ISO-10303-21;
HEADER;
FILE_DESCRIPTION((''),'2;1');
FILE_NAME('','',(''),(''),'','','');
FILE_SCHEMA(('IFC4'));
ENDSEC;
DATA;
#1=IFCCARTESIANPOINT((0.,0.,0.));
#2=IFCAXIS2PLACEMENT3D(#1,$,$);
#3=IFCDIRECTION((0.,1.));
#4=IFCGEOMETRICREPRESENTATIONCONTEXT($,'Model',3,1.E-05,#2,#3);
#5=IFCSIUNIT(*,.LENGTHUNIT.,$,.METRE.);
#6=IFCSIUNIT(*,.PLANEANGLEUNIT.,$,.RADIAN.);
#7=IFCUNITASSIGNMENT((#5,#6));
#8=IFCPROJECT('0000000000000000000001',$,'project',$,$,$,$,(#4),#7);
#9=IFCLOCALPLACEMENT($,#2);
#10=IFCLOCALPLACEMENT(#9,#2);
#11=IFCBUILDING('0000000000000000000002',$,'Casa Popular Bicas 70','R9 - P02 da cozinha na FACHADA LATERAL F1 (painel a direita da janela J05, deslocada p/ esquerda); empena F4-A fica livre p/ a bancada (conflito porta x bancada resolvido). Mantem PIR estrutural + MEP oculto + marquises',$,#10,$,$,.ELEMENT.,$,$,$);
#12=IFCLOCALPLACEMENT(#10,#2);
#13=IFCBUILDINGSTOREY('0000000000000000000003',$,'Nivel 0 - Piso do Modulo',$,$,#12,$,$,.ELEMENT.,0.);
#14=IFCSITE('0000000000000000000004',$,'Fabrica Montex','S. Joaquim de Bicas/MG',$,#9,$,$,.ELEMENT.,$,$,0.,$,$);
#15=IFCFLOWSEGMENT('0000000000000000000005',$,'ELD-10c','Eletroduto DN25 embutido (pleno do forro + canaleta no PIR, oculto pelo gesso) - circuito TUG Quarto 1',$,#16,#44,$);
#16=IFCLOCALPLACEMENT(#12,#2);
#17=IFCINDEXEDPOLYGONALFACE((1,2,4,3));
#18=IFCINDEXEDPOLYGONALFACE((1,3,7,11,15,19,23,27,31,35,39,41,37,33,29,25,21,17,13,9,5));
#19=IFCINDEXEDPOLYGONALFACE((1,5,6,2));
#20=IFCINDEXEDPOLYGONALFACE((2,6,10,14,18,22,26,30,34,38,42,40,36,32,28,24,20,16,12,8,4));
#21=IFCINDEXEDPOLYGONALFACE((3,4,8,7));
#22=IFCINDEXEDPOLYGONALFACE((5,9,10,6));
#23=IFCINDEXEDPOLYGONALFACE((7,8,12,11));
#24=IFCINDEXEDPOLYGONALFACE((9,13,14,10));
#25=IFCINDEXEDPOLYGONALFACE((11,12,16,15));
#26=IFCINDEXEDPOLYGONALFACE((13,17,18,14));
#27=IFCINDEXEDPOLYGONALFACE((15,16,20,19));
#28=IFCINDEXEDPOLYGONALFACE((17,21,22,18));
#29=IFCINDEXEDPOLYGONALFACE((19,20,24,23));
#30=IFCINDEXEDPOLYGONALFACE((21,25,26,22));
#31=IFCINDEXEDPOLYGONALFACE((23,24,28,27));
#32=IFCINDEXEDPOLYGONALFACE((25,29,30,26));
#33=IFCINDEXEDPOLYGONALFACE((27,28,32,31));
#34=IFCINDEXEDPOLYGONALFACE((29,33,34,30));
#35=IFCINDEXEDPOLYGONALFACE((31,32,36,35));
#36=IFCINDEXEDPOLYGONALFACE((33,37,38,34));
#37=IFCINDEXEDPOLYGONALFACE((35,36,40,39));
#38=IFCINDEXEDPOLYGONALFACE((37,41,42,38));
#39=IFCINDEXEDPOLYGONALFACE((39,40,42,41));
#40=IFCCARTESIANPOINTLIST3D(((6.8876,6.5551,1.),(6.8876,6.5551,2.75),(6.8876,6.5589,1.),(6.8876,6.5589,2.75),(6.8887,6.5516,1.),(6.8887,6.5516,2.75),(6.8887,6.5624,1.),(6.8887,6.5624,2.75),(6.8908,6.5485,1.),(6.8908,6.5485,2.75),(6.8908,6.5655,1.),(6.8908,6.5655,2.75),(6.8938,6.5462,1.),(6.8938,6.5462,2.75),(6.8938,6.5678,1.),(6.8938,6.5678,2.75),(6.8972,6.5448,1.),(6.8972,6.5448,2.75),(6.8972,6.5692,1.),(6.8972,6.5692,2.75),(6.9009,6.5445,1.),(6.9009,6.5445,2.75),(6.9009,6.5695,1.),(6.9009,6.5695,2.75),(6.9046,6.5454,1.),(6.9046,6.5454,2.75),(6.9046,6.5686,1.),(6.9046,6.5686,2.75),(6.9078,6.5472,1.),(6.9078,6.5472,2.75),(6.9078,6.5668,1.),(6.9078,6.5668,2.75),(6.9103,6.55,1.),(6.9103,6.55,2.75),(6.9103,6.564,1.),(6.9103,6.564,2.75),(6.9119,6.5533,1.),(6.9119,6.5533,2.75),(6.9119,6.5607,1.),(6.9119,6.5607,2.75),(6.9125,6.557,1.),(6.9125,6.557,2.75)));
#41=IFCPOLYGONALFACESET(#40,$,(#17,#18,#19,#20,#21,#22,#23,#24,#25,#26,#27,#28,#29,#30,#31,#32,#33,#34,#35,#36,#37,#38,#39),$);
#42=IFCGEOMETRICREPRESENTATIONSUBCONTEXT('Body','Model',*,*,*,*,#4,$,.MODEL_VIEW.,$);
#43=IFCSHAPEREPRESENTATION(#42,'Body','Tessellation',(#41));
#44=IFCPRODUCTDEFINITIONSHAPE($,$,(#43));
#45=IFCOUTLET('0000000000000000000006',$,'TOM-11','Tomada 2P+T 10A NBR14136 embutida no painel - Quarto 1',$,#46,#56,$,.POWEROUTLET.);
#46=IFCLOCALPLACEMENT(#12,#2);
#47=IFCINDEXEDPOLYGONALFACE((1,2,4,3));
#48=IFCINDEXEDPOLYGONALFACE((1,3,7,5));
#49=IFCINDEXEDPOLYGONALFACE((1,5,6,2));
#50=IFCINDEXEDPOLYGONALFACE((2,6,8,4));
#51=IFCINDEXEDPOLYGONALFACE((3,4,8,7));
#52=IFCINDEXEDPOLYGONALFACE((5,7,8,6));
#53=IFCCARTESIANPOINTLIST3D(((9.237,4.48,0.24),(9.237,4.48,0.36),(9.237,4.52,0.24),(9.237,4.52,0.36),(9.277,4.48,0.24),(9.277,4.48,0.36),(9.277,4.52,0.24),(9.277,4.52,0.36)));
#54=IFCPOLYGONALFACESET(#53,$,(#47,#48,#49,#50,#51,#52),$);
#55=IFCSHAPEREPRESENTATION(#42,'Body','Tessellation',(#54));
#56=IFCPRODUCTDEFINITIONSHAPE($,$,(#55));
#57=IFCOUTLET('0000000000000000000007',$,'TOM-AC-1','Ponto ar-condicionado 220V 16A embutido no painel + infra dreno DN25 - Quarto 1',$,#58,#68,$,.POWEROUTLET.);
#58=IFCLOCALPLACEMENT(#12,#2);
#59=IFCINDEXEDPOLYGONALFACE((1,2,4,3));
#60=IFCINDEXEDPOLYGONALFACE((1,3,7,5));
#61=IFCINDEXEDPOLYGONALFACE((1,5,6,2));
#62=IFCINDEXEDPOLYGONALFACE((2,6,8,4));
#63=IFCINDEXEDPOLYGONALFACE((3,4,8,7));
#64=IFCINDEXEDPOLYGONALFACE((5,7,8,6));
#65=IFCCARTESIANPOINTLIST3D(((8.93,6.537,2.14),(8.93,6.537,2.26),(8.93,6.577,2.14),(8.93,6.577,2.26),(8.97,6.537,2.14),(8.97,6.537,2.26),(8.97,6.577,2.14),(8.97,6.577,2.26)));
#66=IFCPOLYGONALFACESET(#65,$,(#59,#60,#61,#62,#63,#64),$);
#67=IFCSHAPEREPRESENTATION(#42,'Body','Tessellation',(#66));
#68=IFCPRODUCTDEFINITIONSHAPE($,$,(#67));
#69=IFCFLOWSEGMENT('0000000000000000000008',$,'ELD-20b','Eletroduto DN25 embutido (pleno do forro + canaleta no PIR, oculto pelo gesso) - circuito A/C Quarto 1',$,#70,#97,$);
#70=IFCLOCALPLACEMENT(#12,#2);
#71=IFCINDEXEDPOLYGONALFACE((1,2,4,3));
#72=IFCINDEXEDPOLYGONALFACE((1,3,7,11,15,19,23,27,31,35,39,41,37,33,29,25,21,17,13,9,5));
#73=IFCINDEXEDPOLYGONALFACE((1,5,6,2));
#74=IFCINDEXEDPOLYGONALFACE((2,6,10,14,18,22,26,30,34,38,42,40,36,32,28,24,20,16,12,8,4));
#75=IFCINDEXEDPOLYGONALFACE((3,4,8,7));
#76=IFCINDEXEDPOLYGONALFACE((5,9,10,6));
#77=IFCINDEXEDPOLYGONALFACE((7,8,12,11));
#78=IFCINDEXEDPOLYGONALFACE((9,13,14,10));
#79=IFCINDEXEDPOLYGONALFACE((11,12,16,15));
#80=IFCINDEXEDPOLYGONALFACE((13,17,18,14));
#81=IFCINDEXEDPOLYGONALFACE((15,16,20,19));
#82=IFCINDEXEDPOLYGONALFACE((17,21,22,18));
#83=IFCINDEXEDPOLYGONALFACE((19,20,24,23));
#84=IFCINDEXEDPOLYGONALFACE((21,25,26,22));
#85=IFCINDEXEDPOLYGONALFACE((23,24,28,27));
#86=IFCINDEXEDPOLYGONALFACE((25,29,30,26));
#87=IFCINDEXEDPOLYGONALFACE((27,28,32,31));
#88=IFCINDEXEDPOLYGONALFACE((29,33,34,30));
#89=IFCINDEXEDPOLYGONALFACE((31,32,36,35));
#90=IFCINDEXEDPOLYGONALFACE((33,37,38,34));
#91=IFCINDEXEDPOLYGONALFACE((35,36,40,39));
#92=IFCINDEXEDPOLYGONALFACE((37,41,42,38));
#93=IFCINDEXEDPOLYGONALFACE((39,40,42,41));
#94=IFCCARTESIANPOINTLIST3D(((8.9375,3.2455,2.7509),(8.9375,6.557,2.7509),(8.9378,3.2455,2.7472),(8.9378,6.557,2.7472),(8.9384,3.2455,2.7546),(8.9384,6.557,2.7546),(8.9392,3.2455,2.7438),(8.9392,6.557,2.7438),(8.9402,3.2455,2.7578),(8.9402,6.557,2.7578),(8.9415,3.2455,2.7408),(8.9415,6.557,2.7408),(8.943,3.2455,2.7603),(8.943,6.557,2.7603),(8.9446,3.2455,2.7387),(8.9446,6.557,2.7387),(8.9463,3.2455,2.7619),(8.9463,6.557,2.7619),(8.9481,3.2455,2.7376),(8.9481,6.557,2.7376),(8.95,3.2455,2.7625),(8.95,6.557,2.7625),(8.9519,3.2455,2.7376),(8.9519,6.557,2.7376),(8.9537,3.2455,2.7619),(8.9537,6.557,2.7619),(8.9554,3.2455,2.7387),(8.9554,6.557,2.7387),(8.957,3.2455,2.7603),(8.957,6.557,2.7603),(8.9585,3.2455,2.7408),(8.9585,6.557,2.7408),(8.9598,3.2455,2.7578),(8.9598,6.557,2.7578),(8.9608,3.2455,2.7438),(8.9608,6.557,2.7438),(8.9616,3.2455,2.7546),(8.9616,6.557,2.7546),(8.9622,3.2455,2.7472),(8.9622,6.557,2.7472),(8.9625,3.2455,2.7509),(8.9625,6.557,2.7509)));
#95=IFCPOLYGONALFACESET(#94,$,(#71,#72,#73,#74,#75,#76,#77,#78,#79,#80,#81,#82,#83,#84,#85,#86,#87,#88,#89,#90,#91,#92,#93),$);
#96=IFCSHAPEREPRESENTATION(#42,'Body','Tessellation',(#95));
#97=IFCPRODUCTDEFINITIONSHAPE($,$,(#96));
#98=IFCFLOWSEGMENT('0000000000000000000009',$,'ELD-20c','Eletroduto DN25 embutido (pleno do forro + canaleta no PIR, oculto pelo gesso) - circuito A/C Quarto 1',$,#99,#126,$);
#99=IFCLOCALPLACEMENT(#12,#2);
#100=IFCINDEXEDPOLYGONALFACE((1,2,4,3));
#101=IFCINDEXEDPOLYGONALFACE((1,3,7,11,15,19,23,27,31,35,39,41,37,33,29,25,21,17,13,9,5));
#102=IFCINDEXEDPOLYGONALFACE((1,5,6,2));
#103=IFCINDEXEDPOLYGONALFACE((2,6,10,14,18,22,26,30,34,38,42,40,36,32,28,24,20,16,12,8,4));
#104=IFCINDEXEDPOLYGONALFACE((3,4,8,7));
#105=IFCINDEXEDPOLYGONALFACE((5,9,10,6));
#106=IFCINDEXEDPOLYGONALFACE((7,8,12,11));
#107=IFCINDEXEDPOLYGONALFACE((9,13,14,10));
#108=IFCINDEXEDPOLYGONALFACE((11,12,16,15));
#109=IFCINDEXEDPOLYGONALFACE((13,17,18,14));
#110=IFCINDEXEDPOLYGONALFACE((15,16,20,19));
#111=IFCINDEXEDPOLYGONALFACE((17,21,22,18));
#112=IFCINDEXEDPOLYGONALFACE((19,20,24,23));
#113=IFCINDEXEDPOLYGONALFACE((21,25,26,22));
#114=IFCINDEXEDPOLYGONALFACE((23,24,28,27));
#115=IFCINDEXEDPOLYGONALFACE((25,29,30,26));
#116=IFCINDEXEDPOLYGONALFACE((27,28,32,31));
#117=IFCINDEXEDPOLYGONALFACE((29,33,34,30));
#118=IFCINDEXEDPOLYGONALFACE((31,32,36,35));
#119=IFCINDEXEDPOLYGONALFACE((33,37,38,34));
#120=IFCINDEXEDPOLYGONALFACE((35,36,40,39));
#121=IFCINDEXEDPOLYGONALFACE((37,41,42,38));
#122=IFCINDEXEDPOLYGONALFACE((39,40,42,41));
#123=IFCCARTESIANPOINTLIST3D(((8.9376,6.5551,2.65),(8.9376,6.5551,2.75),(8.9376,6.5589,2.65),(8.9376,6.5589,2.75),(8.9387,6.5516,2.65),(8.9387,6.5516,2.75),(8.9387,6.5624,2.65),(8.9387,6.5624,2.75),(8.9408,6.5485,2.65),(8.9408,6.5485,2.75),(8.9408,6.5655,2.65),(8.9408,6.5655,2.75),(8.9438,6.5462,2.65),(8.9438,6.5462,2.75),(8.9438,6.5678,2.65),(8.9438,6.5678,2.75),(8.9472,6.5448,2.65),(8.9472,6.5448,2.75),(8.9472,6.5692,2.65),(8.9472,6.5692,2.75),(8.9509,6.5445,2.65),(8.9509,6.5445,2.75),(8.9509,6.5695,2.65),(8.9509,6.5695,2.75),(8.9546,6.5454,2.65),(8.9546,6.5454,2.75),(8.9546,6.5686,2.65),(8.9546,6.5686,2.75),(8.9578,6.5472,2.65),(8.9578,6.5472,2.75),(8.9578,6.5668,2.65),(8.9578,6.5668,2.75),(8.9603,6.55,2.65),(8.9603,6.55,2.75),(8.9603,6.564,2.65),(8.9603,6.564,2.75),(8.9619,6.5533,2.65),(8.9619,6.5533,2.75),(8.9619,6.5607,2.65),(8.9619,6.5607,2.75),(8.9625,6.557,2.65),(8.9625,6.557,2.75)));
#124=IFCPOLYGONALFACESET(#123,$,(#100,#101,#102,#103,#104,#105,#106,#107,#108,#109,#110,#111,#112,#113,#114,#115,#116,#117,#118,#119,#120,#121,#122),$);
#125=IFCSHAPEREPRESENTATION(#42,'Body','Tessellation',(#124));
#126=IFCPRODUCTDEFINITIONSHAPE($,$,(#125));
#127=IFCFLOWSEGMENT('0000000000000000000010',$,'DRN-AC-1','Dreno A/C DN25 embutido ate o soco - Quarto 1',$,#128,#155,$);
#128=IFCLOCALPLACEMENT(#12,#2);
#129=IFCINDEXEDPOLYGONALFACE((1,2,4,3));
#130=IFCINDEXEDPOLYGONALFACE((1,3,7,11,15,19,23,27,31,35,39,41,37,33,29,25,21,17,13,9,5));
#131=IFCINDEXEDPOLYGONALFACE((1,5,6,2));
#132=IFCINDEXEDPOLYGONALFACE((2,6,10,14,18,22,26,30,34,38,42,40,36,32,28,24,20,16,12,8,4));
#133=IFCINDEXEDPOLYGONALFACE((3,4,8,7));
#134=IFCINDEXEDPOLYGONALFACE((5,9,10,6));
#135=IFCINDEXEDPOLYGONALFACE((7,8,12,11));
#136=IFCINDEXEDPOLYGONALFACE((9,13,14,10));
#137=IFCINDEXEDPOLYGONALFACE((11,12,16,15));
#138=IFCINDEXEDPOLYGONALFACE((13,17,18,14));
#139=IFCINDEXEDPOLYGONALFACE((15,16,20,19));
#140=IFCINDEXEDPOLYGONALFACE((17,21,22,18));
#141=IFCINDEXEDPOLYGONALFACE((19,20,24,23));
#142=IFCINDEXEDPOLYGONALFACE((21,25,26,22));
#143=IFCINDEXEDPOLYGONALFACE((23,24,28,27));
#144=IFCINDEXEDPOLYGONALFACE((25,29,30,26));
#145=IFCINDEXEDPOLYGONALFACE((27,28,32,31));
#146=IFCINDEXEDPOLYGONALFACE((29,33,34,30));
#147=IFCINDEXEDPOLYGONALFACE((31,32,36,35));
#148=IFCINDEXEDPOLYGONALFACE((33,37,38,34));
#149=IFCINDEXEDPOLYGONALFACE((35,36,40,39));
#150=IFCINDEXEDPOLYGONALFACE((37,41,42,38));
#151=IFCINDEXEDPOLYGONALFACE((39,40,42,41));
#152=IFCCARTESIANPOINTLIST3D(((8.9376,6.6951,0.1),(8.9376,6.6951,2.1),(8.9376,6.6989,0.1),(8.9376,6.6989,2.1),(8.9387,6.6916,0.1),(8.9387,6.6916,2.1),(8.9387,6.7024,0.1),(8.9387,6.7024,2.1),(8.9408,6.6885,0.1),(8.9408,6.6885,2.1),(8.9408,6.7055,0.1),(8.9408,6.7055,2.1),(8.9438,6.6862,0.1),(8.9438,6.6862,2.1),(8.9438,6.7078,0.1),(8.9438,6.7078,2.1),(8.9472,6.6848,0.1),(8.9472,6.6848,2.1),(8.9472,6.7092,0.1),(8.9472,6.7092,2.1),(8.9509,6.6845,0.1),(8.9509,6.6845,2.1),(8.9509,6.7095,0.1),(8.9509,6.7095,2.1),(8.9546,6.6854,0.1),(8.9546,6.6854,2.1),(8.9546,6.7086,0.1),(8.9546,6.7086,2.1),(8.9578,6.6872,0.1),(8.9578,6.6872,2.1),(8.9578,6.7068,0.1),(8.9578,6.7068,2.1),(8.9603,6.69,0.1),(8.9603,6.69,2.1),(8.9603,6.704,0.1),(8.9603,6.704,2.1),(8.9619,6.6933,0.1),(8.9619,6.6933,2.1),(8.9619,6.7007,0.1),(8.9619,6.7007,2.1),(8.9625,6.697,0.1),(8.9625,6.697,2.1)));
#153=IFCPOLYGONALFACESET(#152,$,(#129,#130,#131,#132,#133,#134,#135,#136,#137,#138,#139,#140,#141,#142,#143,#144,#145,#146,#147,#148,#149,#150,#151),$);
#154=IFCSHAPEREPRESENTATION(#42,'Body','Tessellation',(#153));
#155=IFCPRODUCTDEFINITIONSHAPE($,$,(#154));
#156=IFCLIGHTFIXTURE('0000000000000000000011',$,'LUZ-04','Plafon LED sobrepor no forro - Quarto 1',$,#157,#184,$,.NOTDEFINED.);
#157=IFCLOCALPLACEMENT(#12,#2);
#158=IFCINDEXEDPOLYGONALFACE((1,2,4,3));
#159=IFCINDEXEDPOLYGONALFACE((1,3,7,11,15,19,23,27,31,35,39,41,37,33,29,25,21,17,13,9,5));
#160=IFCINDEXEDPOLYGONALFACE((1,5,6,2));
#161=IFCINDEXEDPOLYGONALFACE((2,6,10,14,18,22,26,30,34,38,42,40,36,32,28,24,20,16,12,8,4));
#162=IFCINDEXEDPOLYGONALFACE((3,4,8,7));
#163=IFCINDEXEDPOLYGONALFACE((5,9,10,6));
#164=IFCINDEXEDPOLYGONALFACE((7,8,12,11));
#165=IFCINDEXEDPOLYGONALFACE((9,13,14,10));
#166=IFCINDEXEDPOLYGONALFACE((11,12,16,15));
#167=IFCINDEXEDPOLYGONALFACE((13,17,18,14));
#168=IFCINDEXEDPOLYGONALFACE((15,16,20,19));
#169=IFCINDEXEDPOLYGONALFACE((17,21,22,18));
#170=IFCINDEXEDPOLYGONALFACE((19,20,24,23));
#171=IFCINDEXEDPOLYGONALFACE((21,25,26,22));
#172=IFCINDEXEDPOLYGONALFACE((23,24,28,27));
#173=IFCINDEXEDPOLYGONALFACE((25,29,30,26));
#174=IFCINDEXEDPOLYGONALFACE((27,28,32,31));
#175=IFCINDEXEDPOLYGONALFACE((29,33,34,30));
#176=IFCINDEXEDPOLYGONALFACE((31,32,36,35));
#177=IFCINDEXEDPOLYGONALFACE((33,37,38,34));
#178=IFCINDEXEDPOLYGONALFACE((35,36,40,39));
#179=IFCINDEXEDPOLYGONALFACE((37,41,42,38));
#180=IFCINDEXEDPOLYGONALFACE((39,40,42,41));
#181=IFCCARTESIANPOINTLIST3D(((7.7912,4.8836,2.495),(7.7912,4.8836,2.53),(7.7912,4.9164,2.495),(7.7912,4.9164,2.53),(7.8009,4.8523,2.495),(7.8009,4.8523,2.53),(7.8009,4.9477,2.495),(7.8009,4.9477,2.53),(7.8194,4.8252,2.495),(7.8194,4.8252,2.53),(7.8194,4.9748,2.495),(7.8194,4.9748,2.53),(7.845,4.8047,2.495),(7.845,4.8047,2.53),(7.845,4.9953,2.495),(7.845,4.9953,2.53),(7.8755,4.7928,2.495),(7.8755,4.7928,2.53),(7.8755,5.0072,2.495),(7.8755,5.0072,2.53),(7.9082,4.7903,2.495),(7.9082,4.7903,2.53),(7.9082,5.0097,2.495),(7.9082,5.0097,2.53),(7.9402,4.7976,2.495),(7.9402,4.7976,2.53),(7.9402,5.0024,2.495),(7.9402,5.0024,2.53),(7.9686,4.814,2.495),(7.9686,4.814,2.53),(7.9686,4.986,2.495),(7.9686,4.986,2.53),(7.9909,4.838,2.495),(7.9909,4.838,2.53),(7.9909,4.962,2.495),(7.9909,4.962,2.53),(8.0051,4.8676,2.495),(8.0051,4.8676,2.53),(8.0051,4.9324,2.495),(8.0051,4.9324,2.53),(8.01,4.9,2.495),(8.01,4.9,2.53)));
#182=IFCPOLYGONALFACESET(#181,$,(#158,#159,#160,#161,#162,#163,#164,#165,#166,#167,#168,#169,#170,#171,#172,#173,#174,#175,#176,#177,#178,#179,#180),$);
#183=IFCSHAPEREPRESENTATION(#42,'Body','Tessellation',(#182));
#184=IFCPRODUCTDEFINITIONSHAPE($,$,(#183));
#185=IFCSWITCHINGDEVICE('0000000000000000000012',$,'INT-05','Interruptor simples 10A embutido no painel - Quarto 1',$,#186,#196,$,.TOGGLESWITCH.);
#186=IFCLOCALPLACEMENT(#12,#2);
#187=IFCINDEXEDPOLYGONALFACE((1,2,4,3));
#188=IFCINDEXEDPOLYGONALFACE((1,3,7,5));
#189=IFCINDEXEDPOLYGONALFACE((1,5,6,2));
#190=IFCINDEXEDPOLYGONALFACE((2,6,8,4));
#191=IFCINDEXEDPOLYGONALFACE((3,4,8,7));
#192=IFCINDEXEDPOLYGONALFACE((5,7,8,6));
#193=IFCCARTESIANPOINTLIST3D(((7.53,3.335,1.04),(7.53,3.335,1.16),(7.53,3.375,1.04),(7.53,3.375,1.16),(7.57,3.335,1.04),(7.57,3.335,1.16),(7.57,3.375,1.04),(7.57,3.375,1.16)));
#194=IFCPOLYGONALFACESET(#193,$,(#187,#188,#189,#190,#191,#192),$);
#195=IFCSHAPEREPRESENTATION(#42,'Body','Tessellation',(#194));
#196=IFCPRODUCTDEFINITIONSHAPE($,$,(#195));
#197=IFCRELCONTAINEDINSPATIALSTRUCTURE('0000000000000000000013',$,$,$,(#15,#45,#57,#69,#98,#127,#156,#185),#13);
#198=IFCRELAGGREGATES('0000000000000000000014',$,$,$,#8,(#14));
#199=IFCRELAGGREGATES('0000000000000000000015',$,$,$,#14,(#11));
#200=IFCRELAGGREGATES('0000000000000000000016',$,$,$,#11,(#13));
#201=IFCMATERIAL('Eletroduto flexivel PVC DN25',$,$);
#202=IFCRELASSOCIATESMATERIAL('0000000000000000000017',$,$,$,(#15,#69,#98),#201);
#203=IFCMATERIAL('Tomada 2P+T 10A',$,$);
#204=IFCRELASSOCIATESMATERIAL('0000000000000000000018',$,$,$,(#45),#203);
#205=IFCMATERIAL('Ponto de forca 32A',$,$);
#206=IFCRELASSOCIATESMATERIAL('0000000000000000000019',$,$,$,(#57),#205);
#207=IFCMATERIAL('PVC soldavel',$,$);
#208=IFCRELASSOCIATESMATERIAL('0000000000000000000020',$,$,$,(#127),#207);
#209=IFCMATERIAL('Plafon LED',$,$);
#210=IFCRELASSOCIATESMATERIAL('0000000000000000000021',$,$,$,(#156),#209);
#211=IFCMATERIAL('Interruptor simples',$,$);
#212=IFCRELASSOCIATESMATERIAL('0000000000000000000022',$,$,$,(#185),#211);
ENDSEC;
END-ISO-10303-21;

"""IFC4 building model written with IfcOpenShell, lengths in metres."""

from ifc_helpers import new_model, si_unit, direction, frame, frame_2d, origin, origin_2d, place, context, subcontext, project, spatial, rectangle, circle, extrude, material, element, save


model = new_model("IFC4")

# Units and contexts
model_context = context("Model", 3, precision=1e-05, world=origin(), true_north=direction((0.0, 1.0)))
body_context = subcontext(model_context, "Body", "Model", "MODEL_VIEW")
ifc_project = project(units=[si_unit("LENGTHUNIT", "METRE"), si_unit("PLANEANGLEUNIT", "RADIAN")], contexts=[model_context])

# Site, building, storey
site_placement = place(None, origin())
site = spatial("IfcSite", under=ifc_project, at=site_placement, Name="Fabrica Montex", Description="S. Joaquim de Bicas/MG", CompositionType="ELEMENT", RefElevation=0.0)
building_placement = place(site_placement, origin())
building = spatial("IfcBuilding", under=site, at=building_placement, Name="Casa Popular Bicas 70", Description="R9 - P02 da cozinha na FACHADA LATERAL F1 (painel a direita da janela J05, deslocada p/ esquerda); empena F4-A fica livre p/ a bancada (conflito porta x bancada resolvido). Mantem PIR estrutural + MEP oculto + marquises", CompositionType="ELEMENT")
storey_placement = place(building_placement, origin())
storey = spatial("IfcBuildingStorey", under=building, at=storey_placement, Name="Nivel 0 - Piso do Modulo", CompositionType="ELEMENT", Elevation=0.0)

# Shared definitions
ifc_material_1 = material(Name="Eletroduto flexivel PVC DN25")

# Shared definitions
ifc_material_2 = material(Name="Tomada 2P+T 10A")

# Flow segment
flow_segment_1_placement = place(storey_placement, frame((6.9, 6.557, 2.75), z_axis=(0.0, 0.0, -1.0), x_axis=(1.0, 0.0, 0.0)))
element("IfcFlowSegment", 1, at=flow_segment_1_placement, inside=storey, material=ifc_material_1, Name="ELD-10c", Description="Eletroduto DN25 embutido (pleno do forro + canaleta no PIR, oculto pelo gesso) - circuito TUG Quarto 1", context=body_context, shape_type="SweptSolid", body=[
    extrude(circle(Radius=0.0125, at=origin_2d()), origin(), (0.0, 0.0, 1.0), 1.75),
])

# Outlets
outlet_1_placement = place(storey_placement, frame((9.237, 4.48, 0.24)))
element("IfcOutlet", 2, at=outlet_1_placement, inside=storey, material=ifc_material_2, Name="TOM-11", Description="Tomada 2P+T 10A NBR14136 embutida no painel - Quarto 1", PredefinedType="POWEROUTLET", context=body_context, shape_type="SweptSolid", body=[
    extrude(rectangle(XDim=0.04, YDim=0.04, at=frame_2d((0.02, 0.02))), origin(), (0.0, 0.0, 1.0), 0.12),
])
ifc_material_3 = material(Name="Ponto de forca 32A")
outlet_2_placement = place(storey_placement, frame((8.93, 6.537, 2.14)))
element("IfcOutlet", 3, at=outlet_2_placement, inside=storey, material=ifc_material_3, Name="TOM-AC-1", Description="Ponto ar-condicionado 220V 16A embutido no painel + infra dreno DN25 - Quarto 1", PredefinedType="POWEROUTLET", context=body_context, shape_type="SweptSolid", body=[
    extrude(rectangle(XDim=0.04, YDim=0.04, at=frame_2d((0.02, 0.02))), origin(), (0.0, 0.0, 1.0), 0.12),
])

# Flow segments
flow_segment_2_placement = place(storey_placement, frame((8.95, 3.2455, 2.75), z_axis=(0.0, 1.0, 0.0), x_axis=(0.0, 0.0, 1.0)))
element("IfcFlowSegment", 4, at=flow_segment_2_placement, inside=storey, material=ifc_material_1, Name="ELD-20b", Description="Eletroduto DN25 embutido (pleno do forro + canaleta no PIR, oculto pelo gesso) - circuito A/C Quarto 1", context=body_context, shape_type="SweptSolid", body=[
    extrude(circle(Radius=0.0125, at=origin_2d()), origin(), (0.0, 0.0, 1.0), 3.3115),
])
flow_segment_3_placement = place(storey_placement, frame((8.95, 6.557, 2.75), z_axis=(0.0, 0.0, -1.0), x_axis=(1.0, 0.0, 0.0)))
element("IfcFlowSegment", 5, at=flow_segment_3_placement, inside=storey, material=ifc_material_1, Name="ELD-20c", Description="Eletroduto DN25 embutido (pleno do forro + canaleta no PIR, oculto pelo gesso) - circuito A/C Quarto 1", context=body_context, shape_type="SweptSolid", body=[
    extrude(circle(Radius=0.0125, at=origin_2d()), origin(), (0.0, 0.0, 1.0), 0.1),
])
ifc_material_4 = material(Name="PVC soldavel")
flow_segment_4_placement = place(storey_placement, frame((8.95, 6.697, 2.1), z_axis=(0.0, 0.0, -1.0), x_axis=(1.0, 0.0, 0.0)))
element("IfcFlowSegment", 6, at=flow_segment_4_placement, inside=storey, material=ifc_material_4, Name="DRN-AC-1", Description="Dreno A/C DN25 embutido ate o soco - Quarto 1", context=body_context, shape_type="SweptSolid", body=[
    extrude(circle(Radius=0.0125, at=origin_2d()), origin(), (0.0, 0.0, 1.0), 2.0),
])

# Light fixture
ifc_material_5 = material(Name="Plafon LED")
light_fixture_placement = place(storey_placement, frame((7.9, 4.9, 2.495)))
element("IfcLightFixture", 7, at=light_fixture_placement, inside=storey, material=ifc_material_5, Name="LUZ-04", Description="Plafon LED sobrepor no forro - Quarto 1", PredefinedType="NOTDEFINED", context=body_context, shape_type="SweptSolid", body=[
    extrude(circle(Radius=0.11, at=origin_2d()), origin(), (0.0, 0.0, 1.0), 0.035),
])

# Switching device
ifc_material_6 = material(Name="Interruptor simples")
switching_device_placement = place(storey_placement, frame((7.53, 3.335, 1.04)))
element("IfcSwitchingDevice", 8, at=switching_device_placement, inside=storey, material=ifc_material_6, Name="INT-05", Description="Interruptor simples 10A embutido no painel - Quarto 1", PredefinedType="TOGGLESWITCH", context=body_context, shape_type="SweptSolid", body=[
    extrude(rectangle(XDim=0.04, YDim=0.04, at=frame_2d((0.02, 0.02))), origin(), (0.0, 0.0, 1.0), 0.12),
])

save(model, "model.ifc")
